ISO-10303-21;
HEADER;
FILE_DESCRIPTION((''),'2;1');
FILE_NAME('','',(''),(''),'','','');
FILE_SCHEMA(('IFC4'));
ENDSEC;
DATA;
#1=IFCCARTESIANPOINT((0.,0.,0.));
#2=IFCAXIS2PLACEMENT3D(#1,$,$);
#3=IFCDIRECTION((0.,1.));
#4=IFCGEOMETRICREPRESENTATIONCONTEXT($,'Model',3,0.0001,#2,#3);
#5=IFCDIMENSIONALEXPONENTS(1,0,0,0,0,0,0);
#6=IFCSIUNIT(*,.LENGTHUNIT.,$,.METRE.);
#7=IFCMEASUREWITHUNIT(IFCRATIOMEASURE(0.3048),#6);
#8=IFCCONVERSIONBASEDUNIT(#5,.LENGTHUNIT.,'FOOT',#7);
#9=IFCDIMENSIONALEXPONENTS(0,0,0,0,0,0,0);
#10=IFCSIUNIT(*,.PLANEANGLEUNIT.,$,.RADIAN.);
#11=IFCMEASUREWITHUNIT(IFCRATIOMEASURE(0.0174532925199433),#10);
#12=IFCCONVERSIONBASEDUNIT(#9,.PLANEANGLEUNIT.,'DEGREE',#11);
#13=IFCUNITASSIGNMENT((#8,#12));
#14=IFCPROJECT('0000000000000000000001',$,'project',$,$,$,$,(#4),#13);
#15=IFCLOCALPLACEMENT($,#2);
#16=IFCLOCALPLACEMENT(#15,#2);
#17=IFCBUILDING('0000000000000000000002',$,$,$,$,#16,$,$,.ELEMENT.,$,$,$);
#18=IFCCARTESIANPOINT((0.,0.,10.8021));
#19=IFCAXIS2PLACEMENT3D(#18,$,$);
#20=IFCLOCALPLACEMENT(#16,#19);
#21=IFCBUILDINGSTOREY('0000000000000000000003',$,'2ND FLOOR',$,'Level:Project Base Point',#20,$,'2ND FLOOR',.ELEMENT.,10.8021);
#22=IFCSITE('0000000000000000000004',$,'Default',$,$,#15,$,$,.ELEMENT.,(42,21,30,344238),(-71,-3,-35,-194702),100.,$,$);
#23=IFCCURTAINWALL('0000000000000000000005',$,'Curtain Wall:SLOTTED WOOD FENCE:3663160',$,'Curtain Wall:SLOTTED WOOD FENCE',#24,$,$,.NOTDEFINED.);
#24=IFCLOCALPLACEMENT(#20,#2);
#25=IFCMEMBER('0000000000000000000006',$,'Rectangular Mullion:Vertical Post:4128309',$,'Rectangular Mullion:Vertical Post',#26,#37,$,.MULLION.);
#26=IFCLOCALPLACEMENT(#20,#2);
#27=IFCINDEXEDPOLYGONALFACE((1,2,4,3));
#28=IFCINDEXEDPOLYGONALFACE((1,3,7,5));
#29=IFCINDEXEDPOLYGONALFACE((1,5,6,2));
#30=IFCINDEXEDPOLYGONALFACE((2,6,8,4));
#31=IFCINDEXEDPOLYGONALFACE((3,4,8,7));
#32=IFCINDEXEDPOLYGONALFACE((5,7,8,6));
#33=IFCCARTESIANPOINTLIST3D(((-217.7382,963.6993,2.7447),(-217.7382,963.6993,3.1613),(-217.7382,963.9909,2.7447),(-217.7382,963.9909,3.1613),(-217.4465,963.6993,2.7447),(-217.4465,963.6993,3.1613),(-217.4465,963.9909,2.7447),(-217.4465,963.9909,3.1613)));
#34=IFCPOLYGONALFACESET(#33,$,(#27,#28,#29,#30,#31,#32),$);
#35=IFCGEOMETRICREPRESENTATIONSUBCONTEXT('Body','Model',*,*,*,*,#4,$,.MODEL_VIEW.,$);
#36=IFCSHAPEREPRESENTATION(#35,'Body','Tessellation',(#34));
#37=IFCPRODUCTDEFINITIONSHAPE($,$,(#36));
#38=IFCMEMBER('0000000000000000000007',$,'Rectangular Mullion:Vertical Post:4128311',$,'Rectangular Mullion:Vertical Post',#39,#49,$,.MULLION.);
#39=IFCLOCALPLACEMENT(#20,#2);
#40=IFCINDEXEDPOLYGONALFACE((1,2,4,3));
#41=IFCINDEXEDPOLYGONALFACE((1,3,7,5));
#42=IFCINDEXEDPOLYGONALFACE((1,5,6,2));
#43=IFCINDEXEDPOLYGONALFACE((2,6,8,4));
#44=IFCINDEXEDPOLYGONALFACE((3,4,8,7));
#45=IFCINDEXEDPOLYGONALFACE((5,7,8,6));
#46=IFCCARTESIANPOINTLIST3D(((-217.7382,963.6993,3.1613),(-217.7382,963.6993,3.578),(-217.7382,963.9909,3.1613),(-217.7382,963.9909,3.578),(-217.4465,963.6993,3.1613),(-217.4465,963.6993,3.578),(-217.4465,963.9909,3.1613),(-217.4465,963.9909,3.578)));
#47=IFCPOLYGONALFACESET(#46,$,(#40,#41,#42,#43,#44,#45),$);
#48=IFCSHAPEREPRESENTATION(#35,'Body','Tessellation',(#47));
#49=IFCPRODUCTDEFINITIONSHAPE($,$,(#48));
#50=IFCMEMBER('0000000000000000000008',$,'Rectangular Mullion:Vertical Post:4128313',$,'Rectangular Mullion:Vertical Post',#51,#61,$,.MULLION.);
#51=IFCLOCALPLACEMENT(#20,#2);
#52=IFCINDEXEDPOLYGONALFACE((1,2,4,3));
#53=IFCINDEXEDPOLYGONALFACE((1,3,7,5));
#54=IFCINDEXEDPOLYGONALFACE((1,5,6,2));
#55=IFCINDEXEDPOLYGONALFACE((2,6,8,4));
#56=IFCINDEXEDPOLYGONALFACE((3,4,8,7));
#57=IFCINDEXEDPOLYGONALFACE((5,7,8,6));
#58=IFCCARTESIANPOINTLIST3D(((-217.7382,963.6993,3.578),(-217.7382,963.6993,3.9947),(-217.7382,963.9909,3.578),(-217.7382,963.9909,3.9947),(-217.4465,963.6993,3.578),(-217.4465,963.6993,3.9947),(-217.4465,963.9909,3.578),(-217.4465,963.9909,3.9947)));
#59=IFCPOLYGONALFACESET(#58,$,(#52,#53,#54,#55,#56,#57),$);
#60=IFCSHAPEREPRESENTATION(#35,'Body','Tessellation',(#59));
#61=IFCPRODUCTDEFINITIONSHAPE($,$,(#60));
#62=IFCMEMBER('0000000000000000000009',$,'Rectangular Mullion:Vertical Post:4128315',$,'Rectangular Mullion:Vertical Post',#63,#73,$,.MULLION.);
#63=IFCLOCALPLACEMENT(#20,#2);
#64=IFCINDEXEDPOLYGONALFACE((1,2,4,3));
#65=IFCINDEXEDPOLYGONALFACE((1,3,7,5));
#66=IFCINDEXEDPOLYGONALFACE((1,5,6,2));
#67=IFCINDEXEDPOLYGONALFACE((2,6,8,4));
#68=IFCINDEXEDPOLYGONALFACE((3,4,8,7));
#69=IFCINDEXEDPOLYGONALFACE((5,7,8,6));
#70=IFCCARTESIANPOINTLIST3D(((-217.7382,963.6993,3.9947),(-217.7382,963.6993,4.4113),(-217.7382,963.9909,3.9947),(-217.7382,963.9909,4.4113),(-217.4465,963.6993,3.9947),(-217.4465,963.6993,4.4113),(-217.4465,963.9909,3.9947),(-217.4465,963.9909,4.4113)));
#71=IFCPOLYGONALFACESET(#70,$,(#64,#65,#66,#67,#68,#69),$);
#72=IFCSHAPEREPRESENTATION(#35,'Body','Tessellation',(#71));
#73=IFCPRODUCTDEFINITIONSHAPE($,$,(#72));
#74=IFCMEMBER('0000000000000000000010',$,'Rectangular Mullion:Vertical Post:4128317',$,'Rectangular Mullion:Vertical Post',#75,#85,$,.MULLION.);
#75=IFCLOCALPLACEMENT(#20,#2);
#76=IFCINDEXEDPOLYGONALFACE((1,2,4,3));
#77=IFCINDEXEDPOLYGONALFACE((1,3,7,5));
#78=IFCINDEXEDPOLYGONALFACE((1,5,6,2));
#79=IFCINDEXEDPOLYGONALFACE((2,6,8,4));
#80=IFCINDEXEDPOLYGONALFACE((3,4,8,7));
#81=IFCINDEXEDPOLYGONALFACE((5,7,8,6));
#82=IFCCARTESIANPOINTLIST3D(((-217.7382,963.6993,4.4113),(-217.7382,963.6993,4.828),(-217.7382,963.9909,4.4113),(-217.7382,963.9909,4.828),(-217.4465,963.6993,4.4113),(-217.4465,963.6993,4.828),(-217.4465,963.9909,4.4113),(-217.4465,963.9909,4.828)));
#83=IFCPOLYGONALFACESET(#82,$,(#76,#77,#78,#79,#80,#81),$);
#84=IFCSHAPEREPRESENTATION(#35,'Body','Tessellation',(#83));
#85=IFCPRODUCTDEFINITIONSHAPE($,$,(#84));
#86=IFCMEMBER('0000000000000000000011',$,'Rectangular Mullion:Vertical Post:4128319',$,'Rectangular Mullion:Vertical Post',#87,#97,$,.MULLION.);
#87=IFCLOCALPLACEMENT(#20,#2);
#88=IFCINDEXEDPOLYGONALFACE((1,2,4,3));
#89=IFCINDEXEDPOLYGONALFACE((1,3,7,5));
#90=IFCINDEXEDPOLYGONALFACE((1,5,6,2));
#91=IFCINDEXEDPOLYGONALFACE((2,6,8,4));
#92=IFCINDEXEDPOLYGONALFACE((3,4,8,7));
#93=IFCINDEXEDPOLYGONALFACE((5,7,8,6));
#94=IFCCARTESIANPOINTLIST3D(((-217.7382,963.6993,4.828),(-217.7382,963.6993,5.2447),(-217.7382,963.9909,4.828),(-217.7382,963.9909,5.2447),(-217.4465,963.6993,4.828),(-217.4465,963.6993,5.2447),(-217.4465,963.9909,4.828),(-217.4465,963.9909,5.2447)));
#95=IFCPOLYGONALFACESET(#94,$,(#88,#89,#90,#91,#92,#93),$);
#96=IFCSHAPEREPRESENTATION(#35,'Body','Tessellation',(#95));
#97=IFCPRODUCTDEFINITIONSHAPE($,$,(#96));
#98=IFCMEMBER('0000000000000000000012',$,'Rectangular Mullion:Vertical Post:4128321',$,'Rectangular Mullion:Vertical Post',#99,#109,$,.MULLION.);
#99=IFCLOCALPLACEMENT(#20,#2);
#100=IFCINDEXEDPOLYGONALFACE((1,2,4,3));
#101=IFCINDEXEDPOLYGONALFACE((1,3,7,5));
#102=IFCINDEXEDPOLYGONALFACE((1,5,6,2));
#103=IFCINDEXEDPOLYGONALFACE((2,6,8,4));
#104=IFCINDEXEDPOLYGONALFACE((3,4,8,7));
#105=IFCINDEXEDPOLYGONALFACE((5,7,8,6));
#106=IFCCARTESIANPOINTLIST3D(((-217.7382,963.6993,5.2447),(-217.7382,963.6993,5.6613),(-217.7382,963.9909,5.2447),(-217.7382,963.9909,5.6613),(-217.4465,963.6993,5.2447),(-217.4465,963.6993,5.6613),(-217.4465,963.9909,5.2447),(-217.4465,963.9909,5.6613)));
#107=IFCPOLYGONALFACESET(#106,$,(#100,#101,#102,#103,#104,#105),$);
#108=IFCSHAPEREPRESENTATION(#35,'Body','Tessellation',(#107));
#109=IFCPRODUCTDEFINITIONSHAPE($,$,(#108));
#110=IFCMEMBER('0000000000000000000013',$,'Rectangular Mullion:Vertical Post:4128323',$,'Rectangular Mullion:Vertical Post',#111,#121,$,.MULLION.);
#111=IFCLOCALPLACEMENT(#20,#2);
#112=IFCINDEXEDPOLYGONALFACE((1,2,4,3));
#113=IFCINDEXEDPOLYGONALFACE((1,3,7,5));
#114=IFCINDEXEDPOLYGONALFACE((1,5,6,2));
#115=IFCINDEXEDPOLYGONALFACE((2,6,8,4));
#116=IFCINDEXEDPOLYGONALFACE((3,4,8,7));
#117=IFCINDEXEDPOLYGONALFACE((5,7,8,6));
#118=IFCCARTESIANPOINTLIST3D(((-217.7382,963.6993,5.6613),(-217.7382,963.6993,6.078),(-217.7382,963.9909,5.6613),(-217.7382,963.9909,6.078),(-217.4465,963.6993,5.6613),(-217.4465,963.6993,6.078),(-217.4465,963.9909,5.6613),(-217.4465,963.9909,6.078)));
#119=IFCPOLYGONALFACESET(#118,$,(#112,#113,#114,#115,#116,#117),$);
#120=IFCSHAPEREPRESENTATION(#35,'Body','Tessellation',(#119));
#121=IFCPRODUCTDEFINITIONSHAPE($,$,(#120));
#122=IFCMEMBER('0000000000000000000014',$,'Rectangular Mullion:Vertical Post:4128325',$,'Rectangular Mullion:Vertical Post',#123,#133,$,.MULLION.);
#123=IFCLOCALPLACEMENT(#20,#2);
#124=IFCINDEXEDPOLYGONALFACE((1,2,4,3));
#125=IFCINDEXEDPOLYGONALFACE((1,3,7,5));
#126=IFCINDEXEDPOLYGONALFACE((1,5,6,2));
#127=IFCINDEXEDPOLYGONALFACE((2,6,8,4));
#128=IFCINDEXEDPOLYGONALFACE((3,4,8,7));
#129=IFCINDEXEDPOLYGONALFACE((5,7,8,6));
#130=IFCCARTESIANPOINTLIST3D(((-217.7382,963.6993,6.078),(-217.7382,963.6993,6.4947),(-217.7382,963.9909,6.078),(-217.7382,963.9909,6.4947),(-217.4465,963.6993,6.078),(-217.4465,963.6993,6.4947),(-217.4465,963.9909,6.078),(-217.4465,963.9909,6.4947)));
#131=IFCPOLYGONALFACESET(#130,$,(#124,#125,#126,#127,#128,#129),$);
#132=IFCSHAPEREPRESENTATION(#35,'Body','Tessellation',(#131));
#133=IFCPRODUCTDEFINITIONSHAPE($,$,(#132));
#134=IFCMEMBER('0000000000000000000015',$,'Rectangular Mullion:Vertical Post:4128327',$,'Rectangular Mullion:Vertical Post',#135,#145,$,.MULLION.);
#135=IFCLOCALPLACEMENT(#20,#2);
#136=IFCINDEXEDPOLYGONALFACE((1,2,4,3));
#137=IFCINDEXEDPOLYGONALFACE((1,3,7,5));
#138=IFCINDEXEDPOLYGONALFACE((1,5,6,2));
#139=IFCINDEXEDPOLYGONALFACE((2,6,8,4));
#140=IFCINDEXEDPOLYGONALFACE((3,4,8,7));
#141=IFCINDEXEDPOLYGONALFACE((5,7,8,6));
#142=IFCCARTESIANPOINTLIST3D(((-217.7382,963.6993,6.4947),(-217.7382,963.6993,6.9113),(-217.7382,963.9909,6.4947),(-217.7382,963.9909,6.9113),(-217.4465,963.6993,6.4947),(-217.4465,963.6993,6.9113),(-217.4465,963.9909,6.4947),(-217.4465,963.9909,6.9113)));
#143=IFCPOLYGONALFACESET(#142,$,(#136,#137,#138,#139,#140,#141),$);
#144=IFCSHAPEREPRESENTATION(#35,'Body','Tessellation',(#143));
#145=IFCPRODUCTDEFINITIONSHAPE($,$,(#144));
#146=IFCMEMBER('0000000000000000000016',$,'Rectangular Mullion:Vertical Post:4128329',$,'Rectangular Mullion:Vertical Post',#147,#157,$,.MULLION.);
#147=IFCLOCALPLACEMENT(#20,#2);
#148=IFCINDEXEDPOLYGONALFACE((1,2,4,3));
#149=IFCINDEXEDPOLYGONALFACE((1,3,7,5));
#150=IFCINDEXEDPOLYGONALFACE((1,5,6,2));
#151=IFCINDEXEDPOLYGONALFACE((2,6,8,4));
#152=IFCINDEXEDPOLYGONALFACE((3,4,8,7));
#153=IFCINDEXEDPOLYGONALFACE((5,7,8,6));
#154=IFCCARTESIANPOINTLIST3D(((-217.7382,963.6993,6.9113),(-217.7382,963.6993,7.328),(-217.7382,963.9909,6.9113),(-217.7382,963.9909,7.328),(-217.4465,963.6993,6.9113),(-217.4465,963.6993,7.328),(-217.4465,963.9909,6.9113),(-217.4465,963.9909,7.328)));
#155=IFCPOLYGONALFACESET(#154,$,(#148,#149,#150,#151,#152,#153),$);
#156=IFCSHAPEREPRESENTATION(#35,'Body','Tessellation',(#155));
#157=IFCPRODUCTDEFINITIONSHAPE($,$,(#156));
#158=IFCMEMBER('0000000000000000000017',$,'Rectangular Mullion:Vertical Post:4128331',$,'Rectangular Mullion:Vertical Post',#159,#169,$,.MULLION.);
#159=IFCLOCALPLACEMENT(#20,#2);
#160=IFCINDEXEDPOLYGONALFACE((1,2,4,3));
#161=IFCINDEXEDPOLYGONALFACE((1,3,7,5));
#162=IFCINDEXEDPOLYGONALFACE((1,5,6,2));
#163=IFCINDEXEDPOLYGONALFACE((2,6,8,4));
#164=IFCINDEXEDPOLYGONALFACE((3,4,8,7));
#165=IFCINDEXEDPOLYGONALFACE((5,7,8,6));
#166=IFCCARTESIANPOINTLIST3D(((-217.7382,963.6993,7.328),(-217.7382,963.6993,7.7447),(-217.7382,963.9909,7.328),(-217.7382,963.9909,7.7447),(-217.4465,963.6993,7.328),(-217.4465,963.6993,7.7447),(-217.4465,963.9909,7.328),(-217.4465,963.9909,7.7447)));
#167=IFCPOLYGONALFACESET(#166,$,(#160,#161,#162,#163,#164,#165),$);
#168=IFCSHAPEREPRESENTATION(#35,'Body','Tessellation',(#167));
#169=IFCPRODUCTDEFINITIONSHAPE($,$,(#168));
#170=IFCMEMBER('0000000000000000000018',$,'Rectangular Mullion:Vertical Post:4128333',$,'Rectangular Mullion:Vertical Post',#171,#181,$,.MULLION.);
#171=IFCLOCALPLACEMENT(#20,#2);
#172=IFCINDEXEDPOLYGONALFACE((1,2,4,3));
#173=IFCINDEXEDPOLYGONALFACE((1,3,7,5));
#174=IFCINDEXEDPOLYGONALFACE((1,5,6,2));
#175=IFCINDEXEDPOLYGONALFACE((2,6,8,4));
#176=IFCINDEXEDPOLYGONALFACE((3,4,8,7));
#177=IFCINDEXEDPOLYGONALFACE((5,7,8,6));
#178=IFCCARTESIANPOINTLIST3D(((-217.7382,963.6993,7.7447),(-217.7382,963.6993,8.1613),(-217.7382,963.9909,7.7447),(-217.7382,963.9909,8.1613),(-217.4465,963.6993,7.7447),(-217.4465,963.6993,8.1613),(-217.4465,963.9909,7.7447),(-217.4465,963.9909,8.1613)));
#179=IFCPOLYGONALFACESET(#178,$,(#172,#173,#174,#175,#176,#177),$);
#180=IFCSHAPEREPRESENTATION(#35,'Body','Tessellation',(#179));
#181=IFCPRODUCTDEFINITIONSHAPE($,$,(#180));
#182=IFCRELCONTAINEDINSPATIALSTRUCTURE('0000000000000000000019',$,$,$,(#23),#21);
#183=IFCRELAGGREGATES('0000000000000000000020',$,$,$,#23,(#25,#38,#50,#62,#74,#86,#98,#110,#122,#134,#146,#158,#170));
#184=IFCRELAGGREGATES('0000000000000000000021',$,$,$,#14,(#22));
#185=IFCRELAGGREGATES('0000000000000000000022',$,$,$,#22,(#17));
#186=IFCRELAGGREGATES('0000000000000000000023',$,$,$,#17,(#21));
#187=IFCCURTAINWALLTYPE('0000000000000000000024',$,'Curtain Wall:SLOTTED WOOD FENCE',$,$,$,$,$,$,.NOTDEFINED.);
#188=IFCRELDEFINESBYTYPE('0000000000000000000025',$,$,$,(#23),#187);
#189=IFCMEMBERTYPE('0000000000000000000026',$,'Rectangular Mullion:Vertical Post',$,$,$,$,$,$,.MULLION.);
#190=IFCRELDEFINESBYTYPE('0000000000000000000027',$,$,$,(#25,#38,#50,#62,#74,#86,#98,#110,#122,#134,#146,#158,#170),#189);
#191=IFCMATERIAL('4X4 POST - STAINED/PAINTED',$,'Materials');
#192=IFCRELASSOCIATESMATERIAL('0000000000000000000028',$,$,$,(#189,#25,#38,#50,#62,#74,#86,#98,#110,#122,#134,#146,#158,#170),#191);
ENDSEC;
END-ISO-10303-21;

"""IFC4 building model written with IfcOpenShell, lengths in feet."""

from ifc_helpers import new_model, entity, si_unit, converted_unit, direction, frame, origin, origin_2d_with_axis, place, context, subcontext, project, spatial, rectangle, extrude, source, transform, mapped, material, material_profile, profile_set, profile_usage, type_object, type_shapes, element, aggregate, save


model = new_model("IFC4")

# Units and contexts
model_context = context("Model", 3, precision=0.0001, world=origin(), true_north=direction((0.0, 1.0)))
body_context = subcontext(model_context, "Body", "Model", "MODEL_VIEW")
ifc_project = project(units=[converted_unit("LENGTHUNIT", "FOOT", entity("IfcRatioMeasure", 0.3048), si_unit("LENGTHUNIT", "METRE"), dimensions=[1, 0, 0, 0, 0, 0, 0]), converted_unit("PLANEANGLEUNIT", "DEGREE", entity("IfcRatioMeasure", 0.0174532925199433), si_unit("PLANEANGLEUNIT", "RADIAN"), dimensions=[0, 0, 0, 0, 0, 0, 0])], contexts=[model_context])

# Site, building, storey
site_placement = place(None, origin())
site = spatial("IfcSite", under=ifc_project, at=site_placement, Name="Default", CompositionType="ELEMENT", RefLatitude=(42, 21, 30, 344238), RefLongitude=(-71, -3, -35, -194702), RefElevation=100.0)
building_placement = place(site_placement, origin())
building = spatial("IfcBuilding", under=site, at=building_placement, CompositionType="ELEMENT")
storey_placement = place(building_placement, frame((0.0, 0.0, 10.8021)))
storey = spatial("IfcBuildingStorey", under=building, at=storey_placement, Name="2ND FLOOR", ObjectType="Level:Project Base Point", LongName="2ND FLOOR", CompositionType="ELEMENT", Elevation=10.8021)

# Curtain wall, members
curtain_wall_type = type_object("IfcCurtainWallType", Name="Curtain Wall:SLOTTED WOOD FENCE", PredefinedType="NOTDEFINED")
curtain_wall_1_placement = place(storey_placement, frame((0.0, 0.0, -10.8021)))
curtain_wall_1 = element("IfcCurtainWall", 1, at=curtain_wall_1_placement, inside=storey, type_object=curtain_wall_type, Name="Curtain Wall:SLOTTED WOOD FENCE:3663160", ObjectType="Curtain Wall:SLOTTED WOOD FENCE", PredefinedType="NOTDEFINED")
ifc_material_1 = material(Name="4X4 POST - STAINED/PAINTED", Category="Materials")
ifc_material_profile = material_profile(ifc_material_1, rectangle(XDim=0.2917, YDim=0.2917, at=origin_2d_with_axis()), Name="Vertical Post")
ifc_profile_set = profile_set([ifc_material_profile], Name="Vertical Post")
ifc_profile_usage_1 = profile_usage(ifc_profile_set)
member_type_1 = type_object("IfcMemberType", Name="Rectangular Mullion:Vertical Post", PredefinedType="MULLION", material=ifc_profile_set)
shared_shape_1 = source(origin(), body_context, "Body", "SweptSolid", [
    extrude(rectangle(XDim=0.2917, YDim=0.2917, at=origin_2d_with_axis()), frame((0.0, -0.2083, -0.4167), z_axis=(0.0, 0.0, 1.0), x_axis=(0.0, -1.0, 0.0)), (0.0, 0.0, 1.0), 0.4167),
])
type_shapes(member_type_1, [shared_shape_1])
member_1_placement = place(storey_placement, frame((-217.8007, 963.8451, 2.7447), z_axis=(0.0, 0.0, -1.0), x_axis=(0.0, -1.0, 0.0)))
member_1 = element("IfcMember", 2, at=member_1_placement, type_object=member_type_1, material=ifc_profile_usage_1, Name="Rectangular Mullion:Vertical Post:4128309", ObjectType="Rectangular Mullion:Vertical Post", PredefinedType="MULLION", context=body_context, shape_type="MappedRepresentation", body=[
    mapped(shared_shape_1, transform((0.0, 0.0, 0.0), scale=1.0)),
])
ifc_profile_usage_2 = profile_usage(ifc_profile_set)
member_2_placement = place(storey_placement, frame((-217.8007, 963.8451, 3.1613), z_axis=(0.0, 0.0, -1.0), x_axis=(0.0, -1.0, 0.0)))
member_2 = element("IfcMember", 3, at=member_2_placement, type_object=member_type_1, material=ifc_profile_usage_2, Name="Rectangular Mullion:Vertical Post:4128311", ObjectType="Rectangular Mullion:Vertical Post", PredefinedType="MULLION", context=body_context, shape_type="MappedRepresentation", body=[
    mapped(shared_shape_1, transform((0.0, 0.0, 0.0), scale=1.0)),
])
ifc_profile_usage_3 = profile_usage(ifc_profile_set)
member_3_placement = place(storey_placement, frame((-217.8007, 963.8451, 3.578), z_axis=(0.0, 0.0, -1.0), x_axis=(0.0, -1.0, 0.0)))
member_3 = element("IfcMember", 4, at=member_3_placement, type_object=member_type_1, material=ifc_profile_usage_3, Name="Rectangular Mullion:Vertical Post:4128313", ObjectType="Rectangular Mullion:Vertical Post", PredefinedType="MULLION", context=body_context, shape_type="MappedRepresentation", body=[
    mapped(shared_shape_1, transform((0.0, 0.0, 0.0), scale=1.0)),
])
ifc_profile_usage_4 = profile_usage(ifc_profile_set)
member_4_placement = place(storey_placement, frame((-217.8007, 963.8451, 3.9947), z_axis=(0.0, 0.0, -1.0), x_axis=(0.0, -1.0, 0.0)))
member_4 = element("IfcMember", 5, at=member_4_placement, type_object=member_type_1, material=ifc_profile_usage_4, Name="Rectangular Mullion:Vertical Post:4128315", ObjectType="Rectangular Mullion:Vertical Post", PredefinedType="MULLION", context=body_context, shape_type="MappedRepresentation", body=[
    mapped(shared_shape_1, transform((0.0, 0.0, 0.0), scale=1.0)),
])
ifc_profile_usage_5 = profile_usage(ifc_profile_set)
member_5_placement = place(storey_placement, frame((-217.8007, 963.8451, 4.4113), z_axis=(0.0, 0.0, -1.0), x_axis=(0.0, -1.0, 0.0)))
member_5 = element("IfcMember", 6, at=member_5_placement, type_object=member_type_1, material=ifc_profile_usage_5, Name="Rectangular Mullion:Vertical Post:4128317", ObjectType="Rectangular Mullion:Vertical Post", PredefinedType="MULLION", context=body_context, shape_type="MappedRepresentation", body=[
    mapped(shared_shape_1, transform((0.0, 0.0, 0.0), scale=1.0)),
])
ifc_profile_usage_6 = profile_usage(ifc_profile_set)
member_6_placement = place(storey_placement, frame((-217.8007, 963.8451, 4.828), z_axis=(0.0, 0.0, -1.0), x_axis=(0.0, -1.0, 0.0)))
member_6 = element("IfcMember", 7, at=member_6_placement, type_object=member_type_1, material=ifc_profile_usage_6, Name="Rectangular Mullion:Vertical Post:4128319", ObjectType="Rectangular Mullion:Vertical Post", PredefinedType="MULLION", context=body_context, shape_type="MappedRepresentation", body=[
    mapped(shared_shape_1, transform((0.0, 0.0, 0.0), scale=1.0)),
])
ifc_profile_usage_7 = profile_usage(ifc_profile_set)
member_7_placement = place(storey_placement, frame((-217.8007, 963.8451, 5.2447), z_axis=(0.0, 0.0, -1.0), x_axis=(0.0, -1.0, 0.0)))
member_7 = element("IfcMember", 8, at=member_7_placement, type_object=member_type_1, material=ifc_profile_usage_7, Name="Rectangular Mullion:Vertical Post:4128321", ObjectType="Rectangular Mullion:Vertical Post", PredefinedType="MULLION", context=body_context, shape_type="MappedRepresentation", body=[
    mapped(shared_shape_1, transform((0.0, 0.0, 0.0), scale=1.0)),
])
ifc_profile_usage_8 = profile_usage(ifc_profile_set)
member_8_placement = place(storey_placement, frame((-217.8007, 963.8451, 5.6613), z_axis=(0.0, 0.0, -1.0), x_axis=(0.0, -1.0, 0.0)))
member_8 = element("IfcMember", 9, at=member_8_placement, type_object=member_type_1, material=ifc_profile_usage_8, Name="Rectangular Mullion:Vertical Post:4128323", ObjectType="Rectangular Mullion:Vertical Post", PredefinedType="MULLION", context=body_context, shape_type="MappedRepresentation", body=[
    mapped(shared_shape_1, transform((0.0, 0.0, 0.0), scale=1.0)),
])
ifc_profile_usage_9 = profile_usage(ifc_profile_set)
member_9_placement = place(storey_placement, frame((-217.8007, 963.8451, 6.078), z_axis=(0.0, 0.0, -1.0), x_axis=(0.0, -1.0, 0.0)))
member_9 = element("IfcMember", 10, at=member_9_placement, type_object=member_type_1, material=ifc_profile_usage_9, Name="Rectangular Mullion:Vertical Post:4128325", ObjectType="Rectangular Mullion:Vertical Post", PredefinedType="MULLION", context=body_context, shape_type="MappedRepresentation", body=[
    mapped(shared_shape_1, transform((0.0, 0.0, 0.0), scale=1.0)),
])
ifc_profile_usage_10 = profile_usage(ifc_profile_set)
member_10_placement = place(storey_placement, frame((-217.8007, 963.8451, 6.4947), z_axis=(0.0, 0.0, -1.0), x_axis=(0.0, -1.0, 0.0)))
member_10 = element("IfcMember", 11, at=member_10_placement, type_object=member_type_1, material=ifc_profile_usage_10, Name="Rectangular Mullion:Vertical Post:4128327", ObjectType="Rectangular Mullion:Vertical Post", PredefinedType="MULLION", context=body_context, shape_type="MappedRepresentation", body=[
    mapped(shared_shape_1, transform((0.0, 0.0, 0.0), scale=1.0)),
])
ifc_profile_usage_11 = profile_usage(ifc_profile_set)
member_11_placement = place(storey_placement, frame((-217.8007, 963.8451, 6.9113), z_axis=(0.0, 0.0, -1.0), x_axis=(0.0, -1.0, 0.0)))
member_11 = element("IfcMember", 12, at=member_11_placement, type_object=member_type_1, material=ifc_profile_usage_11, Name="Rectangular Mullion:Vertical Post:4128329", ObjectType="Rectangular Mullion:Vertical Post", PredefinedType="MULLION", context=body_context, shape_type="MappedRepresentation", body=[
    mapped(shared_shape_1, transform((0.0, 0.0, 0.0), scale=1.0)),
])
ifc_profile_usage_12 = profile_usage(ifc_profile_set)
member_12_placement = place(storey_placement, frame((-217.8007, 963.8451, 7.328), z_axis=(0.0, 0.0, -1.0), x_axis=(0.0, -1.0, 0.0)))
member_12 = element("IfcMember", 13, at=member_12_placement, type_object=member_type_1, material=ifc_profile_usage_12, Name="Rectangular Mullion:Vertical Post:4128331", ObjectType="Rectangular Mullion:Vertical Post", PredefinedType="MULLION", context=body_context, shape_type="MappedRepresentation", body=[
    mapped(shared_shape_1, transform((0.0, 0.0, 0.0), scale=1.0)),
])
ifc_profile_usage_13 = profile_usage(ifc_profile_set)
member_13_placement = place(storey_placement, frame((-217.8007, 963.8451, 7.7447), z_axis=(0.0, 0.0, -1.0), x_axis=(0.0, -1.0, 0.0)))
member_13 = element("IfcMember", 14, at=member_13_placement, type_object=member_type_1, material=ifc_profile_usage_13, Name="Rectangular Mullion:Vertical Post:4128333", ObjectType="Rectangular Mullion:Vertical Post", PredefinedType="MULLION", context=body_context, shape_type="MappedRepresentation", body=[
    mapped(shared_shape_1, transform((0.0, 0.0, 0.0), scale=1.0)),
])
aggregate(curtain_wall_1, [member_1, member_2, member_3, member_4, member_5, member_6, member_7, member_8, member_9, member_10, member_11, member_12, member_13])

save(model, "model.ifc")
